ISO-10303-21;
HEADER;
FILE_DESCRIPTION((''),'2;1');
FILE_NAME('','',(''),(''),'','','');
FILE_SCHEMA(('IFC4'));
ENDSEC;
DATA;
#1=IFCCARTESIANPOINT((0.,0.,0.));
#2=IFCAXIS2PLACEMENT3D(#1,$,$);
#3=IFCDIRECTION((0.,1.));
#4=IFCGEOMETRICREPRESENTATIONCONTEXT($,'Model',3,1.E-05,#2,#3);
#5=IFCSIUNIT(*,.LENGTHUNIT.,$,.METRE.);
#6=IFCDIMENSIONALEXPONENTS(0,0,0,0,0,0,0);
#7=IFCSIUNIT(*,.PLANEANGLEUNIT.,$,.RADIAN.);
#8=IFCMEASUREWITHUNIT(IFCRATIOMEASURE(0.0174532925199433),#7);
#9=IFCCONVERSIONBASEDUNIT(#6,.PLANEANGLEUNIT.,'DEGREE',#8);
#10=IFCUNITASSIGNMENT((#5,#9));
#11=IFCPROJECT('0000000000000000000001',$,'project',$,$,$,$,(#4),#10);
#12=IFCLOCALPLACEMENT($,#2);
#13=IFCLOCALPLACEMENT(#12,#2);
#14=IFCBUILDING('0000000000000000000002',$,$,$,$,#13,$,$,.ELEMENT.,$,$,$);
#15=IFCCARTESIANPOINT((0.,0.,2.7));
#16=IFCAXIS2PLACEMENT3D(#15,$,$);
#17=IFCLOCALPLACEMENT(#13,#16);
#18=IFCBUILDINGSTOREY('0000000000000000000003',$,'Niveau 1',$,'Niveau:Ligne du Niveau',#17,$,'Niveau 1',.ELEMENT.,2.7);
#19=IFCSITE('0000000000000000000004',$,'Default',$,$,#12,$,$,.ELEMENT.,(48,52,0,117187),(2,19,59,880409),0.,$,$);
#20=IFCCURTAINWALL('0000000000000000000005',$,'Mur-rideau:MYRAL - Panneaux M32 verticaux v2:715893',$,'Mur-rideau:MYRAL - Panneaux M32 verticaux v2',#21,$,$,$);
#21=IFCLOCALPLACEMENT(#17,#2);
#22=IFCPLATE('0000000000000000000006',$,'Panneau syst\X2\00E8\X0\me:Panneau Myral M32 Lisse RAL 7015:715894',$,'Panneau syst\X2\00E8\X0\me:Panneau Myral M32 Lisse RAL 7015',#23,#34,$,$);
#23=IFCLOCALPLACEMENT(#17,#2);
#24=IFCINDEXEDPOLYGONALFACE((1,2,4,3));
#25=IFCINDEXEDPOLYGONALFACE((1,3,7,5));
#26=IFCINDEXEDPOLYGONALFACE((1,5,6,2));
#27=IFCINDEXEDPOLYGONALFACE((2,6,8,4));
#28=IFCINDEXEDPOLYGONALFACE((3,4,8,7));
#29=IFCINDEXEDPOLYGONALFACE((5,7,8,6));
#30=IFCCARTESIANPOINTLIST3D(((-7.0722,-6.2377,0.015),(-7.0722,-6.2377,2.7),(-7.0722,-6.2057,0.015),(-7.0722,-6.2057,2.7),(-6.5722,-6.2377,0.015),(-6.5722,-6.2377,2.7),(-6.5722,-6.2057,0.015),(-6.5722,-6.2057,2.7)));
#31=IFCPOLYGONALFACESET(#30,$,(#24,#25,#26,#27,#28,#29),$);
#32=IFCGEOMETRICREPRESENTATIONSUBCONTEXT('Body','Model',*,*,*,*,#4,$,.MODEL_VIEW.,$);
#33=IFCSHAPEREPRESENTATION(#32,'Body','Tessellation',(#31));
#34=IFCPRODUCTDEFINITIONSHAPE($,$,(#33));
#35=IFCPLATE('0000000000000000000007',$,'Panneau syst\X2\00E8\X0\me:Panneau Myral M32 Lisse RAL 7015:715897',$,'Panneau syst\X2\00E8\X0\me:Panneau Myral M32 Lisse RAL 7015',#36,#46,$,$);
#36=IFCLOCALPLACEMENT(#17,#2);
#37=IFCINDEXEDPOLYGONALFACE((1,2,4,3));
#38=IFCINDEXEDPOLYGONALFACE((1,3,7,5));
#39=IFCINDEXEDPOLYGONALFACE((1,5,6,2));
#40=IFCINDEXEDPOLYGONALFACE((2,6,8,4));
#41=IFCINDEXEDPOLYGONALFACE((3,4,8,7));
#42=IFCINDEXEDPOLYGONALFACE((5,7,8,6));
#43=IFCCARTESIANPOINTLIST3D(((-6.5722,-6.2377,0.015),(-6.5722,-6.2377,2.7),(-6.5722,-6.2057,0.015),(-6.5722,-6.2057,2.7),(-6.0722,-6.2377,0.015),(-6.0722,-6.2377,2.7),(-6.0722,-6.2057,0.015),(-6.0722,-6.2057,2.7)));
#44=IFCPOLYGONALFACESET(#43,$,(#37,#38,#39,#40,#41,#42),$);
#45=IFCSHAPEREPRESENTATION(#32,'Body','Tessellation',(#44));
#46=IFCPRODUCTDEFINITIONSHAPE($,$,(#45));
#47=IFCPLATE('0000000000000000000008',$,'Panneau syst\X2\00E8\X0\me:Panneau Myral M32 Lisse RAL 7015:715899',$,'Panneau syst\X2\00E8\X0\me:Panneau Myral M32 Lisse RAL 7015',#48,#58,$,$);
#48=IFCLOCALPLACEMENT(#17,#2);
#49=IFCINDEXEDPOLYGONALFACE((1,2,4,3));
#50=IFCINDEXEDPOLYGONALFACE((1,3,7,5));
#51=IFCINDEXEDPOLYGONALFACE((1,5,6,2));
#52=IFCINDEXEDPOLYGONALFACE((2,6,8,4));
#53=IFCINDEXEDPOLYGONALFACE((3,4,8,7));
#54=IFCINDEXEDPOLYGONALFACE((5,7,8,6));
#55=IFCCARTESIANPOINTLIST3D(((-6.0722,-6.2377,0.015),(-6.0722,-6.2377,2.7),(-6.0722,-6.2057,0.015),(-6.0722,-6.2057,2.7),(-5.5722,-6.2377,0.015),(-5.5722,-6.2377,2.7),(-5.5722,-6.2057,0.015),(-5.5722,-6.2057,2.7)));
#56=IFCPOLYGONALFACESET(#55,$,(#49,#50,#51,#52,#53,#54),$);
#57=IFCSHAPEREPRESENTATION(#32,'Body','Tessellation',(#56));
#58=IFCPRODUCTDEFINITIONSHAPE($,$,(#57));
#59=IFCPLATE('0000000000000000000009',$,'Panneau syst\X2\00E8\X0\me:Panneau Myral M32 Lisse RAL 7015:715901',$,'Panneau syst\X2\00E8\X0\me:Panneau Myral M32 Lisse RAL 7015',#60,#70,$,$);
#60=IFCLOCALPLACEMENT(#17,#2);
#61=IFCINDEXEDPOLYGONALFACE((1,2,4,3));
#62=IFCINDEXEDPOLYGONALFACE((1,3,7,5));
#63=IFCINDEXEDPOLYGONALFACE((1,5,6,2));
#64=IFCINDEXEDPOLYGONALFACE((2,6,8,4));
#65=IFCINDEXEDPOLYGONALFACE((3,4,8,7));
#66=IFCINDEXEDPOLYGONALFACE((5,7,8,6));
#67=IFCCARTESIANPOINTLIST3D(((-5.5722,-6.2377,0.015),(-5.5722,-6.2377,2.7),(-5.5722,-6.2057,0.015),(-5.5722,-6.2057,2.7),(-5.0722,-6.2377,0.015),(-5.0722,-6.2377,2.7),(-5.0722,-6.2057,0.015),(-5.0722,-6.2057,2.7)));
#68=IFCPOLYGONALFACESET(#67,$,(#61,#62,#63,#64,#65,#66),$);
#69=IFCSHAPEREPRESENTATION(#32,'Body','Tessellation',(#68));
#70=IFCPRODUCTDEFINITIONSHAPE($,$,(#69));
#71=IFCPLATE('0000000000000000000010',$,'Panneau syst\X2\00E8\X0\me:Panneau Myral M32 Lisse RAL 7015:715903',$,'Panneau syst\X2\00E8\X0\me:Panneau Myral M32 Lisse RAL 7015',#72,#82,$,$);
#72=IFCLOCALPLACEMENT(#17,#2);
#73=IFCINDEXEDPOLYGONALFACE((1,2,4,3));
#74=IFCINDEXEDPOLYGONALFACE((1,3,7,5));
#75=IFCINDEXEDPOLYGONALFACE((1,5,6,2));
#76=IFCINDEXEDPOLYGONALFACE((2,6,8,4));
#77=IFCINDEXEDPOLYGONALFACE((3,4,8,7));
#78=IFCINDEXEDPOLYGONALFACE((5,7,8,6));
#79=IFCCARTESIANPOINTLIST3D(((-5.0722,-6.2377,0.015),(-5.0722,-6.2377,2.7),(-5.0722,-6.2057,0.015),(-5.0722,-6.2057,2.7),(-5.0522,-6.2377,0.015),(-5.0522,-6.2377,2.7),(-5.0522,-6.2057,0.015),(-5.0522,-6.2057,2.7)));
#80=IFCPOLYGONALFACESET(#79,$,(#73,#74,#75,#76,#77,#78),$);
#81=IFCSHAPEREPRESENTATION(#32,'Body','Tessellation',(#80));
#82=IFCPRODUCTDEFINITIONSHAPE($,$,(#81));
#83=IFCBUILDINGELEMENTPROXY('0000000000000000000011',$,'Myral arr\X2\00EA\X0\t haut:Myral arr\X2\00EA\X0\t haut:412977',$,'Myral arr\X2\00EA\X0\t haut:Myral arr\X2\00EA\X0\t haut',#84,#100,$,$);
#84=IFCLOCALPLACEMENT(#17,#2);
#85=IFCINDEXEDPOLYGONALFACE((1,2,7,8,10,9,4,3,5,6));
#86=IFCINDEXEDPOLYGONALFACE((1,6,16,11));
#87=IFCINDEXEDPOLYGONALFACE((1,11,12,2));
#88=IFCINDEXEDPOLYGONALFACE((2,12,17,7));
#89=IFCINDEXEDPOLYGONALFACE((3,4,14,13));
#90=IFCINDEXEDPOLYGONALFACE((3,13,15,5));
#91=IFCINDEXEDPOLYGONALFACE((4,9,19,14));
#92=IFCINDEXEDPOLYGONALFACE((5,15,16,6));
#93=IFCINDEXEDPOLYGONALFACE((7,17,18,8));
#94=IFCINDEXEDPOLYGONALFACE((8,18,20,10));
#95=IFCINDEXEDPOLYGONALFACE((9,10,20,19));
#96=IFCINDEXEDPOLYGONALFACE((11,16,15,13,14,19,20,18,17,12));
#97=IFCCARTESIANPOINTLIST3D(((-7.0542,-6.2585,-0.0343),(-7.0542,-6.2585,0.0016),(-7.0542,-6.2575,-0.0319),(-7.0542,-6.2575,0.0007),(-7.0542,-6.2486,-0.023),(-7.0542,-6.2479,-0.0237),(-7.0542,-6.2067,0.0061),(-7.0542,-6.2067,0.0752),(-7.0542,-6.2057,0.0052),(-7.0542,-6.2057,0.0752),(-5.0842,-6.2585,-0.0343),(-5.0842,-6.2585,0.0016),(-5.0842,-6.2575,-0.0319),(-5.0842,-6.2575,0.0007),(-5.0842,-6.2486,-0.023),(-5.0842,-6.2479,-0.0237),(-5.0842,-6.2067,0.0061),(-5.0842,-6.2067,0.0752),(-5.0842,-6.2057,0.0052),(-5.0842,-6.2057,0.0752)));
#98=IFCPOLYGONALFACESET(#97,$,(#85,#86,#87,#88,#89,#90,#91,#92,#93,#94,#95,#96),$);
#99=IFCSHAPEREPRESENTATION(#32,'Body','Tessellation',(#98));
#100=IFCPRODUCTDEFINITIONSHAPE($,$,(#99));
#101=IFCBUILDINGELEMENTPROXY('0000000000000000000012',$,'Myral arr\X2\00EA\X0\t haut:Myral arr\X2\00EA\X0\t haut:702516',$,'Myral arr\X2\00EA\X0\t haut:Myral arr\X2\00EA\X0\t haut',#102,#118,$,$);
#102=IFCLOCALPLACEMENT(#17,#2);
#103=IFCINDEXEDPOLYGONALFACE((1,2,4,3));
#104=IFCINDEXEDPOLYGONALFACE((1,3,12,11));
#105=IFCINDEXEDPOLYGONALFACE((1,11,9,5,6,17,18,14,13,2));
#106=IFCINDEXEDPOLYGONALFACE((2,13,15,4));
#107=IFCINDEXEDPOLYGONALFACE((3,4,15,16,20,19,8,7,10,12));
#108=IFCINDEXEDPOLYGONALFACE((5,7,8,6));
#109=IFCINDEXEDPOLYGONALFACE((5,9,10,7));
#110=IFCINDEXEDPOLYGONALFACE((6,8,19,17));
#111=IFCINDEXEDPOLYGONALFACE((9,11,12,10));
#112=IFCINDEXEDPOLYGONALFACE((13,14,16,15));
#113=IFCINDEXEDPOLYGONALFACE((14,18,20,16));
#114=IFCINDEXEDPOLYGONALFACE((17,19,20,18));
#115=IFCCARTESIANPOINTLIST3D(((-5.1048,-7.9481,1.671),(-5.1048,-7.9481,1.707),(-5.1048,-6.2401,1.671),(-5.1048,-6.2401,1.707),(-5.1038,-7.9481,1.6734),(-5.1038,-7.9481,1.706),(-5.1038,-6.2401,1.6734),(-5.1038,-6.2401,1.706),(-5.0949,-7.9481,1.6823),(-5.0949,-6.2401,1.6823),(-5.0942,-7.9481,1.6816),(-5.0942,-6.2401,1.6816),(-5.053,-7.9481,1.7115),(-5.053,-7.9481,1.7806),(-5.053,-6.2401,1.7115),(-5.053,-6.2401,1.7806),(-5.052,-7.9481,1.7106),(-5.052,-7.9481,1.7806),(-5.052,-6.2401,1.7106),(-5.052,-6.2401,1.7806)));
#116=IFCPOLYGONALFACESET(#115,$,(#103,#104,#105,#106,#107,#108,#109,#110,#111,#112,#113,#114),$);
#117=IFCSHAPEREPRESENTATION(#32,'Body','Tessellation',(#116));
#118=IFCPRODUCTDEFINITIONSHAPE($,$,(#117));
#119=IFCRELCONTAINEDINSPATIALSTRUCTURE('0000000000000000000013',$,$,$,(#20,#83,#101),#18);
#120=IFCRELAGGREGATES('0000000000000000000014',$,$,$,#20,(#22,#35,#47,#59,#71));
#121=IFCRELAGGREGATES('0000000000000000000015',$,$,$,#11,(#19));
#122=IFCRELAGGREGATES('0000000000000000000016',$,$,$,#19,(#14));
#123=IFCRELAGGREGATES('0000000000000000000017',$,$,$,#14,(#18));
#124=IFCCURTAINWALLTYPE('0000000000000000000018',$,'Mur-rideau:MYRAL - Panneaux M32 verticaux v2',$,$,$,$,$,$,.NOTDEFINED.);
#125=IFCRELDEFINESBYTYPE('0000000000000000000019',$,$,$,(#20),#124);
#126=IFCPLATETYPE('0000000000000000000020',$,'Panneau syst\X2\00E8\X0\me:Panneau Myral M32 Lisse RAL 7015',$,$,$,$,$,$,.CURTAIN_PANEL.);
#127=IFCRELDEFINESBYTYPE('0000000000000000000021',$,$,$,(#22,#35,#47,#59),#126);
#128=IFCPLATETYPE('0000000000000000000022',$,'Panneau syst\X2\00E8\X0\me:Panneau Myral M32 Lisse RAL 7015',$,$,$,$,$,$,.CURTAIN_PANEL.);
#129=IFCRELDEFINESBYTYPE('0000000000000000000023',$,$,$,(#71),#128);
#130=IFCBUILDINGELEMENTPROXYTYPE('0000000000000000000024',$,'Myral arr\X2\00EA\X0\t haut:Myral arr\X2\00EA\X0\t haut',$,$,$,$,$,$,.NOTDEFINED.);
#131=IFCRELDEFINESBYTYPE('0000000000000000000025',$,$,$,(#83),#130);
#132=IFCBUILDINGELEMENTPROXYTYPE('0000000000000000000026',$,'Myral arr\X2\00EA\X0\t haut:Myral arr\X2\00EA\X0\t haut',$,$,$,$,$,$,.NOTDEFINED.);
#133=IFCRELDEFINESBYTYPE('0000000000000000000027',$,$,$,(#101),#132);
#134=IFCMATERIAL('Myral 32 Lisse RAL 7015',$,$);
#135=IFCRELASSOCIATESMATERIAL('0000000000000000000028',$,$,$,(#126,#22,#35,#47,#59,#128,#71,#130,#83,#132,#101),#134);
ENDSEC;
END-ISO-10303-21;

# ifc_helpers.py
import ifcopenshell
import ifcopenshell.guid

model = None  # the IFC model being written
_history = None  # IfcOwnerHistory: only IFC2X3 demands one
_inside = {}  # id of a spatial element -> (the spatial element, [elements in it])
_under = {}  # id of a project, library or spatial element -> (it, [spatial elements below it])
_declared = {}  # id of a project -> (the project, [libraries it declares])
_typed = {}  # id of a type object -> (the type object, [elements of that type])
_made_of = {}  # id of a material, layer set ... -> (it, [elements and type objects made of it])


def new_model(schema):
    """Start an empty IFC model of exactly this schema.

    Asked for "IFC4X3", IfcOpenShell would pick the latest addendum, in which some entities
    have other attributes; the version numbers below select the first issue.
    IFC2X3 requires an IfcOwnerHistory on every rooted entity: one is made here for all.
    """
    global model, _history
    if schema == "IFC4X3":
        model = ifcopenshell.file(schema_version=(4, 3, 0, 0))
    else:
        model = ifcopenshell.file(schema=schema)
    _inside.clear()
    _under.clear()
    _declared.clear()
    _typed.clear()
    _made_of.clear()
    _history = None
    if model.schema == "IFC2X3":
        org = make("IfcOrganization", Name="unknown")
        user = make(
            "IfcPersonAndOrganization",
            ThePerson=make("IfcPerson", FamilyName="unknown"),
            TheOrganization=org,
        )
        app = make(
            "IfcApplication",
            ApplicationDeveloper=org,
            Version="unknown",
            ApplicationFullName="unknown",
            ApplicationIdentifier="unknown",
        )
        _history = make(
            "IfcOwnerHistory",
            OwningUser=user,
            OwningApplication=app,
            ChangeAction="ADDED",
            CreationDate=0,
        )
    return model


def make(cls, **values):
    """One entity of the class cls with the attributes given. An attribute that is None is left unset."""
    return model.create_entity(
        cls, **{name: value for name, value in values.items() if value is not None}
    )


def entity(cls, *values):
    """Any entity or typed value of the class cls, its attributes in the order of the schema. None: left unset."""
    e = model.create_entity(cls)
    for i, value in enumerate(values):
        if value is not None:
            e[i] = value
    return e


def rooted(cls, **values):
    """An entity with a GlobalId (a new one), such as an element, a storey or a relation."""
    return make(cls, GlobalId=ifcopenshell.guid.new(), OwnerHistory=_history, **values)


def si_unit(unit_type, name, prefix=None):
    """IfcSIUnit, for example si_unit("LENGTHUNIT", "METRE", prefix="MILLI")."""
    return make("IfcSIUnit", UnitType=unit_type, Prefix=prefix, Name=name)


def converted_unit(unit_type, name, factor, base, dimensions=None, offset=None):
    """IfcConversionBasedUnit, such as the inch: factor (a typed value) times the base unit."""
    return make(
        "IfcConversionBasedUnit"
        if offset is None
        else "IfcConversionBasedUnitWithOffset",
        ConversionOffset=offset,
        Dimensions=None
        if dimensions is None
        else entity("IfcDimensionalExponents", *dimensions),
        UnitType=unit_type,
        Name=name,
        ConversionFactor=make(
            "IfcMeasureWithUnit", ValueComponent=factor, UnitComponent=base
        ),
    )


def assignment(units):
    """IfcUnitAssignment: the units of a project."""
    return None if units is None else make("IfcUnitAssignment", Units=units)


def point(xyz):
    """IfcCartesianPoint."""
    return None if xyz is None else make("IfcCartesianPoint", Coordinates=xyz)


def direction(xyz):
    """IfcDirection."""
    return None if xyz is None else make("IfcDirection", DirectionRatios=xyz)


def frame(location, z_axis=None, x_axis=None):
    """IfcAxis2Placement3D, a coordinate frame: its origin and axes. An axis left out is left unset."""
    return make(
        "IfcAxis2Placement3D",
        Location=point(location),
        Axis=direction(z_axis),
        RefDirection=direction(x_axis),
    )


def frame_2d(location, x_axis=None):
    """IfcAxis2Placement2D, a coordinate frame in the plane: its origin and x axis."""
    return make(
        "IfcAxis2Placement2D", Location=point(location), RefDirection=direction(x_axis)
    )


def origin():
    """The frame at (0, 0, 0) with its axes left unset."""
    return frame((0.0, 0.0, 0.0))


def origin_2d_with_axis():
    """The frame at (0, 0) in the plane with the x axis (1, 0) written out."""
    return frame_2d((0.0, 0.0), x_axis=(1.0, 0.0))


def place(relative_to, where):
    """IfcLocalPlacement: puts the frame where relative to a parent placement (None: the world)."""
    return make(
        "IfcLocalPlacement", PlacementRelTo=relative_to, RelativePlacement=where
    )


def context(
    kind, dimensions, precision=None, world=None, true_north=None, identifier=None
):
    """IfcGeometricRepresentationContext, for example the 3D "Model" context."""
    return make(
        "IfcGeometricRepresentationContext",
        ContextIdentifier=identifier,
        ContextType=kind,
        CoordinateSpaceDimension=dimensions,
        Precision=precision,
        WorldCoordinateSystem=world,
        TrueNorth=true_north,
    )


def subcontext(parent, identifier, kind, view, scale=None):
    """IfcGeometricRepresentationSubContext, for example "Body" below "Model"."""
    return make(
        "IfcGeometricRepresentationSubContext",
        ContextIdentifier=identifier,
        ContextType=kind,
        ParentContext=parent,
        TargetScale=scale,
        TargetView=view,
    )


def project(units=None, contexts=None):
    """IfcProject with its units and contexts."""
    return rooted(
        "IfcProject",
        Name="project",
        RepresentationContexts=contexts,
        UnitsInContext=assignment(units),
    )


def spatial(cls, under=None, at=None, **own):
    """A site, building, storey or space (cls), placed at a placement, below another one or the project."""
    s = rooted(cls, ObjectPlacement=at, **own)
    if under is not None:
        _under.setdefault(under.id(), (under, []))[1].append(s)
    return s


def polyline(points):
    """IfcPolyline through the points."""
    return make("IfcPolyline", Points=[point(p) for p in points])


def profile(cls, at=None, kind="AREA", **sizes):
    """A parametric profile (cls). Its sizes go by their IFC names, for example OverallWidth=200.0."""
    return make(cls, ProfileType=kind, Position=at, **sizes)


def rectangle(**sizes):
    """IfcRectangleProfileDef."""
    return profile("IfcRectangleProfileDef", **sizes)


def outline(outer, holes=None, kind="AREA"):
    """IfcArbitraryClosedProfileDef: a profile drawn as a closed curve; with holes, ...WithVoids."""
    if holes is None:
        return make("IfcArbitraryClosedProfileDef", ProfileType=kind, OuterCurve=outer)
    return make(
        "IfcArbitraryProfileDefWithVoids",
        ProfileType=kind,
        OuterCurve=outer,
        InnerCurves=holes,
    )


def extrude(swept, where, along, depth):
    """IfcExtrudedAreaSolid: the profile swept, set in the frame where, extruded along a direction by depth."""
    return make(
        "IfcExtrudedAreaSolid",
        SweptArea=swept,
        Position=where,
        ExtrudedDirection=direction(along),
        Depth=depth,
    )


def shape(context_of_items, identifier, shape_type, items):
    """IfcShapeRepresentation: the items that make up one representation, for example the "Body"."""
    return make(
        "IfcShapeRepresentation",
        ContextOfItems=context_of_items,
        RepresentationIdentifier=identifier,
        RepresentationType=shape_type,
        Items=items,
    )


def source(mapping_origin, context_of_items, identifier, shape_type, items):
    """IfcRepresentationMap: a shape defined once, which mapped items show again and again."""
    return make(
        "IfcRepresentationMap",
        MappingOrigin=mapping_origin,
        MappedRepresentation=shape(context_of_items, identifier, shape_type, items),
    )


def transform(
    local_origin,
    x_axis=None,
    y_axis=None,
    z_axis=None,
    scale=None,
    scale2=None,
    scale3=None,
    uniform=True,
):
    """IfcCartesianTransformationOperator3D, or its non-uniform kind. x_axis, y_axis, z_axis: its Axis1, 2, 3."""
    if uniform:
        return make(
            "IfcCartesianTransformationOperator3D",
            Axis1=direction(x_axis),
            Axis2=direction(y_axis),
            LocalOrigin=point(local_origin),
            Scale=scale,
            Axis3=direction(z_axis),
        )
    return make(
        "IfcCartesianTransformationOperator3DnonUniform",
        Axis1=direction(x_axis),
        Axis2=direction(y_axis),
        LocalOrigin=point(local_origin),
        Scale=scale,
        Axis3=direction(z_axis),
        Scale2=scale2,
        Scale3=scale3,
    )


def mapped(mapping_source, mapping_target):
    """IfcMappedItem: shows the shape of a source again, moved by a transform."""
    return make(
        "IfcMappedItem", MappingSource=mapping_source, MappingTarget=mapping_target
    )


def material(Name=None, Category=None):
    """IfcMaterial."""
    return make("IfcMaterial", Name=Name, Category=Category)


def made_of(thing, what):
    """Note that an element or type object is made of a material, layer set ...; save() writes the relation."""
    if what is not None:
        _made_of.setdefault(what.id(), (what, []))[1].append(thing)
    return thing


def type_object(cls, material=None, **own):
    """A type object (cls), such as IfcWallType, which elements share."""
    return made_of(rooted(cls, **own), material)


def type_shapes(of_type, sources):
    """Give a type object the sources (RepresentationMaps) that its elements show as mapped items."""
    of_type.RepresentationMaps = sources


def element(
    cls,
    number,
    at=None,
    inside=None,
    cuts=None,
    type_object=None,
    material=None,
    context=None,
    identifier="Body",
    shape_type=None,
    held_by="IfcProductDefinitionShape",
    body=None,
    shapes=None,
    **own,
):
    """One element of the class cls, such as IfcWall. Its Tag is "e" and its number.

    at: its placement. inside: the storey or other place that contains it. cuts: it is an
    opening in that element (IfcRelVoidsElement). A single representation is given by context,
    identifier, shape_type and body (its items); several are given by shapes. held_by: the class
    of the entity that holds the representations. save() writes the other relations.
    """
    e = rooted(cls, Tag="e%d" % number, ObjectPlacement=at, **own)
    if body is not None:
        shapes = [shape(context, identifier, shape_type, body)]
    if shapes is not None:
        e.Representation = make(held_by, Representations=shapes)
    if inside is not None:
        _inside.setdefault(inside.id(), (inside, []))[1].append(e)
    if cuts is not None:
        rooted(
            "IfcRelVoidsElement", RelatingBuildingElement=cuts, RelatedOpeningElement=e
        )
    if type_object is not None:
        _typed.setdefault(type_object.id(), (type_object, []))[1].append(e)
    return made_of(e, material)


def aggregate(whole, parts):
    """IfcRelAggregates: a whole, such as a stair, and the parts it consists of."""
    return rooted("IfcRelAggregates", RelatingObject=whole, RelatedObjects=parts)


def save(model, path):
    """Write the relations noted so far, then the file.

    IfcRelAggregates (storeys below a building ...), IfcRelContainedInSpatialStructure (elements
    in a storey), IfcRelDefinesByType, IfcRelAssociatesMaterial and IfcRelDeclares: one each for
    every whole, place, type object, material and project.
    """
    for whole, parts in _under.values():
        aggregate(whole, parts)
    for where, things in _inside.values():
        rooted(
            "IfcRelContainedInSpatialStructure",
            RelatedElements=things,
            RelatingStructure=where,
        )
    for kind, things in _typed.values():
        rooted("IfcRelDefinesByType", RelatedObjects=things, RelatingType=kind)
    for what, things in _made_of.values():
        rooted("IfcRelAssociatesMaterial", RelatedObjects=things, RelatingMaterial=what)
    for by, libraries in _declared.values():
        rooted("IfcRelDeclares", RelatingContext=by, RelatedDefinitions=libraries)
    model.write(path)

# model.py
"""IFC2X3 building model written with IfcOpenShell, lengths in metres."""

from ifc_helpers import new_model, entity, si_unit, converted_unit, direction, frame, origin, origin_2d_with_axis, place, context, subcontext, project, spatial, polyline, rectangle, outline, extrude, source, transform, mapped, material, type_object, type_shapes, element, aggregate, save


model = new_model("IFC2X3")

# Units and contexts
model_context = context("Model", 3, precision=1e-05, world=origin(), true_north=direction((0.0, 1.0)))
body_context = subcontext(model_context, "Body", "Model", "MODEL_VIEW")
ifc_project = project(units=[si_unit("LENGTHUNIT", "METRE"), converted_unit("PLANEANGLEUNIT", "DEGREE", entity("IfcRatioMeasure", 0.0174532925199433), si_unit("PLANEANGLEUNIT", "RADIAN"), dimensions=[0, 0, 0, 0, 0, 0, 0])], contexts=[model_context])

# Site, building, storey
site_placement = place(None, origin())
site = spatial("IfcSite", under=ifc_project, at=site_placement, Name="Default", CompositionType="ELEMENT", RefLatitude=(48, 52, 0, 117187), RefLongitude=(2, 19, 59, 880409), RefElevation=0.0)
building_placement = place(site_placement, origin())
building = spatial("IfcBuilding", under=site, at=building_placement, CompositionType="ELEMENT")
storey_placement = place(building_placement, frame((0.0, 0.0, 2.7)))
storey = spatial("IfcBuildingStorey", under=building, at=storey_placement, Name="Niveau 1", ObjectType="Niveau:Ligne du Niveau", LongName="Niveau 1", CompositionType="ELEMENT", Elevation=2.7)

# Curtain wall, plates
curtain_wall_type = type_object("IfcCurtainWallType", Name="Mur-rideau:MYRAL - Panneaux M32 verticaux v2", PredefinedType="NOTDEFINED")
curtain_wall_placement = place(storey_placement, frame((0.0, 0.0, -2.7)))
curtain_wall = element("IfcCurtainWall", 1, at=curtain_wall_placement, inside=storey, type_object=curtain_wall_type, Name="Mur-rideau:MYRAL - Panneaux M32 verticaux v2:715893", ObjectType="Mur-rideau:MYRAL - Panneaux M32 verticaux v2")
ifc_material_1 = material(Name="Myral 32 Lisse RAL 7015")
plate_type_1 = type_object("IfcPlateType", Name="Panneau système:Panneau Myral M32 Lisse RAL 7015", PredefinedType="CURTAIN_PANEL", material=ifc_material_1)
shared_shape_1 = source(origin(), body_context, "Body", "SweptSolid", [
    extrude(rectangle(XDim=0.032, YDim=0.5, at=origin_2d_with_axis()), frame((0.0, -0.016, 0.0), z_axis=(0.0, 0.0, 1.0), x_axis=(0.0, 1.0, 0.0)), (0.0, 0.0, 1.0), 2.685),
])
type_shapes(plate_type_1, [shared_shape_1])
plate_1_placement = place(curtain_wall_placement, frame((-6.8222, -6.2057, 2.715)))
plate_1 = element("IfcPlate", 2, at=plate_1_placement, type_object=plate_type_1, material=ifc_material_1, Name="Panneau système:Panneau Myral M32 Lisse RAL 7015:715894", ObjectType="Panneau système:Panneau Myral M32 Lisse RAL 7015", context=body_context, shape_type="MappedRepresentation", body=[
    mapped(shared_shape_1, transform((0.0, 0.0, 0.0), scale=1.0)),
])
plate_2_placement = place(curtain_wall_placement, frame((-6.3222, -6.2057, 2.715)))
plate_2 = element("IfcPlate", 3, at=plate_2_placement, type_object=plate_type_1, material=ifc_material_1, Name="Panneau système:Panneau Myral M32 Lisse RAL 7015:715897", ObjectType="Panneau système:Panneau Myral M32 Lisse RAL 7015", context=body_context, shape_type="MappedRepresentation", body=[
    mapped(shared_shape_1, transform((0.0, 0.0, 0.0), scale=1.0)),
])
plate_3_placement = place(curtain_wall_placement, frame((-5.8222, -6.2057, 2.715)))
plate_3 = element("IfcPlate", 4, at=plate_3_placement, type_object=plate_type_1, material=ifc_material_1, Name="Panneau système:Panneau Myral M32 Lisse RAL 7015:715899", ObjectType="Panneau système:Panneau Myral M32 Lisse RAL 7015", context=body_context, shape_type="MappedRepresentation", body=[
    mapped(shared_shape_1, transform((0.0, 0.0, 0.0), scale=1.0)),
])
plate_4_placement = place(curtain_wall_placement, frame((-5.3222, -6.2057, 2.715)))
plate_4 = element("IfcPlate", 5, at=plate_4_placement, type_object=plate_type_1, material=ifc_material_1, Name="Panneau système:Panneau Myral M32 Lisse RAL 7015:715901", ObjectType="Panneau système:Panneau Myral M32 Lisse RAL 7015", context=body_context, shape_type="MappedRepresentation", body=[
    mapped(shared_shape_1, transform((0.0, 0.0, 0.0), scale=1.0)),
])
plate_type_2 = type_object("IfcPlateType", Name="Panneau système:Panneau Myral M32 Lisse RAL 7015", PredefinedType="CURTAIN_PANEL", material=ifc_material_1)
shared_shape_2 = source(origin(), body_context, "Body", "SweptSolid", [
    extrude(rectangle(XDim=0.032, YDim=0.02, at=origin_2d_with_axis()), frame((0.0, -0.016, 0.0), z_axis=(0.0, 0.0, 1.0), x_axis=(0.0, 1.0, 0.0)), (0.0, 0.0, 1.0), 2.685),
])
type_shapes(plate_type_2, [shared_shape_2])
plate_5_placement = place(curtain_wall_placement, frame((-5.0622, -6.2057, 2.715)))
plate_5 = element("IfcPlate", 6, at=plate_5_placement, type_object=plate_type_2, material=ifc_material_1, Name="Panneau système:Panneau Myral M32 Lisse RAL 7015:715903", ObjectType="Panneau système:Panneau Myral M32 Lisse RAL 7015", context=body_context, shape_type="MappedRepresentation", body=[
    mapped(shared_shape_2, transform((0.0, 0.0, 0.0), scale=1.0)),
])
aggregate(curtain_wall, [plate_1, plate_2, plate_3, plate_4, plate_5])

# Building element proxies
building_element_proxy_type_1 = type_object("IfcBuildingElementProxyType", Name="Myral arrêt haut:Myral arrêt haut", PredefinedType="NOTDEFINED", material=ifc_material_1)
shared_shape_3 = source(origin(), body_context, "Body", "SweptSolid", [
    extrude(outline(polyline([(-0.0394, -0.0232), (-0.0035, -0.0232), (0.001, 0.0286), (0.0701, 0.0286), (0.0701, 0.0296), (0.0001, 0.0296), (-0.0044, -0.0222), (-0.037, -0.0222), (-0.0281, -0.0133), (-0.0288, -0.0126), (-0.0394, -0.0232)])), frame((0.0, -0.0105, -0.0026), z_axis=(1.0, 0.0, 0.0), x_axis=(0.0, -1.0, 0.0)), (0.0, 0.0, 1.0), 1.97),
])
type_shapes(building_element_proxy_type_1, [shared_shape_3])
proxy_1_placement = place(storey_placement, frame((-5.0842, -6.2379, -0.0053), z_axis=(0.0, -1.0, 0.0), x_axis=(-1.0, 0.0, 0.0)))
element("IfcBuildingElementProxy", 7, at=proxy_1_placement, inside=storey, type_object=building_element_proxy_type_1, material=ifc_material_1, Name="Myral arrêt haut:Myral arrêt haut:412977", ObjectType="Myral arrêt haut:Myral arrêt haut", context=body_context, shape_type="MappedRepresentation", body=[
    mapped(shared_shape_3, transform((0.0, 0.0, 0.0), scale=1.0)),
])
building_element_proxy_type_2 = type_object("IfcBuildingElementProxyType", Name="Myral arrêt haut:Myral arrêt haut", PredefinedType="NOTDEFINED", material=ifc_material_1)
shared_shape_4 = source(origin(), body_context, "Body", "SweptSolid", [
    extrude(outline(polyline([(-0.0394, -0.0232), (-0.0035, -0.0232), (0.001, 0.0286), (0.0701, 0.0286), (0.0701, 0.0296), (0.0001, 0.0296), (-0.0044, -0.0222), (-0.037, -0.0222), (-0.0281, -0.0133), (-0.0288, -0.0126), (-0.0394, -0.0232)])), frame((0.0, -0.0105, -0.0026), z_axis=(1.0, 0.0, 0.0), x_axis=(0.0, -1.0, 0.0)), (0.0, 0.0, 1.0), 1.708),
])
type_shapes(building_element_proxy_type_2, [shared_shape_4])
proxy_2_placement = place(storey_placement, frame((-5.0842, -7.9481, 1.7), z_axis=(-1.0, 0.0, 0.0), x_axis=(0.0, 1.0, 0.0)))
element("IfcBuildingElementProxy", 8, at=proxy_2_placement, inside=storey, type_object=building_element_proxy_type_2, material=ifc_material_1, Name="Myral arrêt haut:Myral arrêt haut:702516", ObjectType="Myral arrêt haut:Myral arrêt haut", context=body_context, shape_type="MappedRepresentation", body=[
    mapped(shared_shape_4, transform((0.0, 0.0, 0.0), scale=1.0)),
])

save(model, "model.ifc")
